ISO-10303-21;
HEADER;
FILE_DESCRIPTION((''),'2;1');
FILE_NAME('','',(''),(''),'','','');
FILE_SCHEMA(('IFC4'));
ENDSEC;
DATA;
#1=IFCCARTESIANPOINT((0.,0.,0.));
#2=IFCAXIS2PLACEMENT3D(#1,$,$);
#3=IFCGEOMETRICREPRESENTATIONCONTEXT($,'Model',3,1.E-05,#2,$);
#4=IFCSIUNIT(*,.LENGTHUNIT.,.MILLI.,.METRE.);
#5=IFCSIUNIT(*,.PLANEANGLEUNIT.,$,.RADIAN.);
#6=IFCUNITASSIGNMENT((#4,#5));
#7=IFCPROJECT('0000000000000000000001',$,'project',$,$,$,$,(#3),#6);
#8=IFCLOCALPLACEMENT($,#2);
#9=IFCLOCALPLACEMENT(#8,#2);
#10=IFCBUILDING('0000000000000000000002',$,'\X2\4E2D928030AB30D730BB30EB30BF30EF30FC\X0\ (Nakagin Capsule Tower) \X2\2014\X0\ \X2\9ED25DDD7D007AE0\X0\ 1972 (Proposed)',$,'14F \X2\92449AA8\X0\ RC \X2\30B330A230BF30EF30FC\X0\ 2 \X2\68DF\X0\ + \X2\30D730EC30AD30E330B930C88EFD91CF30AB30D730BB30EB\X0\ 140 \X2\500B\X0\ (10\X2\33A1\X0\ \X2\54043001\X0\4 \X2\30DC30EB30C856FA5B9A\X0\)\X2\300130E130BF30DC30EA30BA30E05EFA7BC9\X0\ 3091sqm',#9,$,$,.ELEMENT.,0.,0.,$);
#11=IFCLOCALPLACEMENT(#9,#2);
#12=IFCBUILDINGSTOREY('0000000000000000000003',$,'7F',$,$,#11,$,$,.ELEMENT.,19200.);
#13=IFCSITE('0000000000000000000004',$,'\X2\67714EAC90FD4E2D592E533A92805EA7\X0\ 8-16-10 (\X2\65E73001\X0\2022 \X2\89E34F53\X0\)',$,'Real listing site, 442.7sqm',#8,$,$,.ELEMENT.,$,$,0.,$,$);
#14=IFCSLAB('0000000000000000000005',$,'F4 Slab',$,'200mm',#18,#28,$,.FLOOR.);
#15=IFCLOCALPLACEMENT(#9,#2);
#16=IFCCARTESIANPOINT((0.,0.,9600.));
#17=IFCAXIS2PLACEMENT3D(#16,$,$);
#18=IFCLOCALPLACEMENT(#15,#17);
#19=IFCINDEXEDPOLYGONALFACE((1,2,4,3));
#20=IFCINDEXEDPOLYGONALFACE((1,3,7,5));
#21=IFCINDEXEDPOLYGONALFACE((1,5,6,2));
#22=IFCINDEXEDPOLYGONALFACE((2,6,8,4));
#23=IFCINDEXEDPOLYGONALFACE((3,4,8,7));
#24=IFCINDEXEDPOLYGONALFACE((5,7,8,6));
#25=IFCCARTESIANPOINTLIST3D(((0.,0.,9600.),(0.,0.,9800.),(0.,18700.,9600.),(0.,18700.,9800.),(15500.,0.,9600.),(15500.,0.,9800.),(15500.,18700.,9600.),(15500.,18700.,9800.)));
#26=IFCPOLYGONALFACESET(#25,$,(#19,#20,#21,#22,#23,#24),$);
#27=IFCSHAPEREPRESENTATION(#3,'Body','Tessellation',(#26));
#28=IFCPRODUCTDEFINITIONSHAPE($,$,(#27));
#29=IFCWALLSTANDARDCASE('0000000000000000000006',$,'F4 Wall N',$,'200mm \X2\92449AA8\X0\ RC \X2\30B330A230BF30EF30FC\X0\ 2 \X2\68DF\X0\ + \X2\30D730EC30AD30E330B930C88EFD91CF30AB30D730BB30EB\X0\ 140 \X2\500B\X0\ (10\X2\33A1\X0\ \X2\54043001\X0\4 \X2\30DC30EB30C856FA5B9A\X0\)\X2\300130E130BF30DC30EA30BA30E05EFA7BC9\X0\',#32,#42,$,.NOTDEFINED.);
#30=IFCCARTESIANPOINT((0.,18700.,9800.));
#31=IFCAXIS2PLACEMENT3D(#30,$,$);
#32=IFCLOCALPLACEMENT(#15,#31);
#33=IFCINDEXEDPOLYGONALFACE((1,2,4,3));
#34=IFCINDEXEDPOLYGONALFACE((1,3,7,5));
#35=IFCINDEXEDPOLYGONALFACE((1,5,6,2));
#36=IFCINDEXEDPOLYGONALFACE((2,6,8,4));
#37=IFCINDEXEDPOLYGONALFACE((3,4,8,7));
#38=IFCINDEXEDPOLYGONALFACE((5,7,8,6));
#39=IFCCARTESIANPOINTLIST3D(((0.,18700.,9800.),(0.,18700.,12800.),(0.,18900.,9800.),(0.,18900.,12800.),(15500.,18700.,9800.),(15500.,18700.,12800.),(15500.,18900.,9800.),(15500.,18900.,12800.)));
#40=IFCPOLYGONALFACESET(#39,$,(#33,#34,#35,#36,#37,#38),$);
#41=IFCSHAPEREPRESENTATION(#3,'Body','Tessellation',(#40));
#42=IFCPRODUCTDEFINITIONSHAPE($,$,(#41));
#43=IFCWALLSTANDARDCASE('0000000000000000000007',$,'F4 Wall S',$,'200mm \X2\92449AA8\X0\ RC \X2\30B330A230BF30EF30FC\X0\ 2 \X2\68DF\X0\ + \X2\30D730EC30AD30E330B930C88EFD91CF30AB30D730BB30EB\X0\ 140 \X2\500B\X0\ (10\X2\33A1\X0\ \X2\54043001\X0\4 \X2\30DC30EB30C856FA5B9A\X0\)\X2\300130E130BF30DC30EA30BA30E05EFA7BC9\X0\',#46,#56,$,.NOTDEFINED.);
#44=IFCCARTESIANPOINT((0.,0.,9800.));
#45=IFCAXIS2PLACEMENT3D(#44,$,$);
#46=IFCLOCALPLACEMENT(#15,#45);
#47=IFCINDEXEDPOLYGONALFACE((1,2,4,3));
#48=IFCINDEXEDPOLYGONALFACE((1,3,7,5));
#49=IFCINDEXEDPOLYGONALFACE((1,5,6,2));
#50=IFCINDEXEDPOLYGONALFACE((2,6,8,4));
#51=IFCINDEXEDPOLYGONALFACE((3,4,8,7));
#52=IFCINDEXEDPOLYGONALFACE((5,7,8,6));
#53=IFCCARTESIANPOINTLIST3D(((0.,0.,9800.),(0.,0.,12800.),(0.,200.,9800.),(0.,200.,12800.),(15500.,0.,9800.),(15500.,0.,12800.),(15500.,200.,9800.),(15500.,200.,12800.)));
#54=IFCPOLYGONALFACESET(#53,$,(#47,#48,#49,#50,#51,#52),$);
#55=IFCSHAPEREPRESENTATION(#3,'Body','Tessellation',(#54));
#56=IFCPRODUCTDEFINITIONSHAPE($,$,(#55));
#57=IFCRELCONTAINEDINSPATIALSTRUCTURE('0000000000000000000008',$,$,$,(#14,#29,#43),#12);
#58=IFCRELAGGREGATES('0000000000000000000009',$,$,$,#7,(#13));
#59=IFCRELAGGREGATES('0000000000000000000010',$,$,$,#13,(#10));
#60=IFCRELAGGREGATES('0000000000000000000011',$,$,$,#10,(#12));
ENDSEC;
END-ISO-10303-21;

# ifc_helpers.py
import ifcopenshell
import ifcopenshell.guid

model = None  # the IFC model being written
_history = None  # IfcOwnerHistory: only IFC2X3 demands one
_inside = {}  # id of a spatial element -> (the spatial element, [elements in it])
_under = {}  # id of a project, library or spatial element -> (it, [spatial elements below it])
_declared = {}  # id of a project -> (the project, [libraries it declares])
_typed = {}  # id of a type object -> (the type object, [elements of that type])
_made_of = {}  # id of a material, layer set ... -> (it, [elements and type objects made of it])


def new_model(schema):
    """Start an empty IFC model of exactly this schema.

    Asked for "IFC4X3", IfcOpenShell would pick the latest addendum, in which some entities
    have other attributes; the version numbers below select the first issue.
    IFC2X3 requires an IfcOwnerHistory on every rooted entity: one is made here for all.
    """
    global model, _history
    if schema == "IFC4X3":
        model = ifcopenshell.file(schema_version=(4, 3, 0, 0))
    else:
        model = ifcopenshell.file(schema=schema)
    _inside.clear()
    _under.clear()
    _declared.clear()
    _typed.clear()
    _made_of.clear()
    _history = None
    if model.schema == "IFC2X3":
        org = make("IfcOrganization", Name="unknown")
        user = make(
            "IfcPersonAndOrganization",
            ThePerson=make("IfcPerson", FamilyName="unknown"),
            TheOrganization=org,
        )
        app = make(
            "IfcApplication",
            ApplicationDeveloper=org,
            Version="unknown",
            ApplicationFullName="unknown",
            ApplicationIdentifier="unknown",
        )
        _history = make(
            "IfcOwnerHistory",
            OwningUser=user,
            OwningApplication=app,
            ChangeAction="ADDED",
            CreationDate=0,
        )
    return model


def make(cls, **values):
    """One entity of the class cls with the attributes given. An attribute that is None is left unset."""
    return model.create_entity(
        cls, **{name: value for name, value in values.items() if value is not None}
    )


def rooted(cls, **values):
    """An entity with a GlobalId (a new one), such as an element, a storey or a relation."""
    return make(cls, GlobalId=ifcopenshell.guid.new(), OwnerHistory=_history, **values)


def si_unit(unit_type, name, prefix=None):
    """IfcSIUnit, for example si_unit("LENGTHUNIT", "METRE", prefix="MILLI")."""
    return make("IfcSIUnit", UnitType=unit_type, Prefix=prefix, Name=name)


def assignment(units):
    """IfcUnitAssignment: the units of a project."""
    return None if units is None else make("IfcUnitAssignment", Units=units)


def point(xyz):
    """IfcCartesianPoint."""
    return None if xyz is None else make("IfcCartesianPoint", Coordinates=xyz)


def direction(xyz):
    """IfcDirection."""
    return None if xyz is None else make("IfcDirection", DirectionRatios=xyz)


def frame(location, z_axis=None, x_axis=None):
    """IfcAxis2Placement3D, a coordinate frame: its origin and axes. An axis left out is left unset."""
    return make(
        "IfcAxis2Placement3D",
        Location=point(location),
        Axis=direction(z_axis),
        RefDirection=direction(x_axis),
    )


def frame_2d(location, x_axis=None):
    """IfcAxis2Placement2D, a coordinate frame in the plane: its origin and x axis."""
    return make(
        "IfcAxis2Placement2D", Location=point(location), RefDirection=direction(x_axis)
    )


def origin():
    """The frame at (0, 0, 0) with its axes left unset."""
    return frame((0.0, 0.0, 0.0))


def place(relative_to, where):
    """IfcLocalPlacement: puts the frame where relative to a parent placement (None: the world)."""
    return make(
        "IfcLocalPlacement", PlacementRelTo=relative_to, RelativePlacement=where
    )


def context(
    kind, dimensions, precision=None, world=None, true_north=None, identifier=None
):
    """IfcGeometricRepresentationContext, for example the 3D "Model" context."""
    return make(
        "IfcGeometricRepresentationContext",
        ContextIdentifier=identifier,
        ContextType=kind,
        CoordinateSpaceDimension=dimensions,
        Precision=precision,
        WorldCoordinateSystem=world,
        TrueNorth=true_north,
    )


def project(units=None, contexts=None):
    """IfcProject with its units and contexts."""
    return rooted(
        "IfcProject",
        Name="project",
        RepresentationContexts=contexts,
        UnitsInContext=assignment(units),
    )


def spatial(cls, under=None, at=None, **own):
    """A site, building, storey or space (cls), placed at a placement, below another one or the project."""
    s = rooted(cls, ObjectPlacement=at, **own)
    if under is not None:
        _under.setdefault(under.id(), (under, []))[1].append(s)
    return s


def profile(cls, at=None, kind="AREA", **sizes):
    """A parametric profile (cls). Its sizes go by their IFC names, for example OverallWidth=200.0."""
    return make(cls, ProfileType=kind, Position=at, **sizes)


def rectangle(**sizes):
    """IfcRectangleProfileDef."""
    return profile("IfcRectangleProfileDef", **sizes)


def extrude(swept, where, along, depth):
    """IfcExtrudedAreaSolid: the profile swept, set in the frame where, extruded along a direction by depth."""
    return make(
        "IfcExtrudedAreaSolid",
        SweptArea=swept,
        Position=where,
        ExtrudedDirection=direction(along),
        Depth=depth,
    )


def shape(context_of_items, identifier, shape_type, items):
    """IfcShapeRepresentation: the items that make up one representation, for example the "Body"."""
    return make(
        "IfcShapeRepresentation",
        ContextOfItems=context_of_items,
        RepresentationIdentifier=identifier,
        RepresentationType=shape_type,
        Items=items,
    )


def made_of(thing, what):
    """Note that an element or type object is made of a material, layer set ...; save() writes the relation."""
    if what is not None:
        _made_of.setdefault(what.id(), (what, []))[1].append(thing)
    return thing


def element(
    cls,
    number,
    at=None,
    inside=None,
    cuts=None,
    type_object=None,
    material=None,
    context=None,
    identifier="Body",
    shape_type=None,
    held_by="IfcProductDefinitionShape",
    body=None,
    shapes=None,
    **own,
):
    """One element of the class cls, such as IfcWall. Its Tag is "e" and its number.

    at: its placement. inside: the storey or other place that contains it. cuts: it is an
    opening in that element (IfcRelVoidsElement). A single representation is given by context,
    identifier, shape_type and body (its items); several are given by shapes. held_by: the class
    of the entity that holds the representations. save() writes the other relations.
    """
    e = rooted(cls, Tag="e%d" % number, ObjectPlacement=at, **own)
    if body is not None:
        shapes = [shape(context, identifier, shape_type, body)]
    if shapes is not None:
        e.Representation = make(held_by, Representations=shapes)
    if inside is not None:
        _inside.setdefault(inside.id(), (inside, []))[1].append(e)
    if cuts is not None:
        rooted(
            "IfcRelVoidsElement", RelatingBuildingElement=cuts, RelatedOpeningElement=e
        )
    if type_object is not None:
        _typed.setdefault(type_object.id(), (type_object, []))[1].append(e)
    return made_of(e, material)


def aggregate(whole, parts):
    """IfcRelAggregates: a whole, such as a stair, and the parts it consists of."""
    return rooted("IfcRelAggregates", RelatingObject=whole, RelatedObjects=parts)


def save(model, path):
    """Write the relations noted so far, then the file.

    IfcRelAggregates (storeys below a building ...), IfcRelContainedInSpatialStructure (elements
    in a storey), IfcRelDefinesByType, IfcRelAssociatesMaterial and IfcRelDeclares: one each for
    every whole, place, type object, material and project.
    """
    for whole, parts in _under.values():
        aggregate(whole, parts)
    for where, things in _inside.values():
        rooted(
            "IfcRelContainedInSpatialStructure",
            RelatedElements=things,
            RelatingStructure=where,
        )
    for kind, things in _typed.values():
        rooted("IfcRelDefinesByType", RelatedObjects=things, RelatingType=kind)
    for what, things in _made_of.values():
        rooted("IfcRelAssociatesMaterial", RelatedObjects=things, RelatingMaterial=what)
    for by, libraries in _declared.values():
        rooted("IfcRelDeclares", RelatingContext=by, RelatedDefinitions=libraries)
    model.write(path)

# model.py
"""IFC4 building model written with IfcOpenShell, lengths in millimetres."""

from ifc_helpers import new_model, si_unit, frame, frame_2d, origin, place, context, project, spatial, rectangle, extrude, element, save


model = new_model("IFC4")

# Units and contexts
model_context = context("Model", 3, precision=1e-05, world=origin())
ifc_project = project(units=[si_unit("LENGTHUNIT", "METRE", prefix="MILLI"), si_unit("PLANEANGLEUNIT", "RADIAN")], contexts=[model_context])

# Site, building, storey
site_placement = place(None, origin())
site = spatial("IfcSite", under=ifc_project, at=site_placement, Name="東京都中央区銀座 8-16-10 (旧、2022 解体)", ObjectType="Real listing site, 442.7sqm", CompositionType="ELEMENT", RefElevation=0.0)
building_placement = place(site_placement, origin())
building = spatial("IfcBuilding", under=site, at=building_placement, Name="中銀カプセルタワー (Nakagin Capsule Tower) — 黒川紀章 1972 (Proposed)", ObjectType="14F 鉄骨 RC コアタワー 2 棟 + プレキャスト軽量カプセル 140 個 (10㎡ 各、4 ボルト固定)、メタボリズム建築 3091sqm", CompositionType="ELEMENT", ElevationOfRefHeight=0.0, ElevationOfTerrain=0.0)
storey_placement = place(building_placement, origin())
storey = spatial("IfcBuildingStorey", under=building, at=storey_placement, Name="7F", CompositionType="ELEMENT", Elevation=19200.0)

# Slab
placement = place(building_placement, origin())
slab_placement = place(placement, frame((0.0, 0.0, 9600.0)))
element("IfcSlab", 1, at=slab_placement, inside=storey, Name="F4 Slab", ObjectType="200mm", PredefinedType="FLOOR", context=model_context, shape_type="SweptSolid", body=[
    extrude(rectangle(XDim=15500.0, YDim=18700.0, at=frame_2d((7750.0, 9350.0))), frame((0.0, 0.0, 9600.0)), (0.0, 0.0, 1.0), 200.0),
])

# Walls
wall_1_placement = place(placement, frame((0.0, 18700.0, 9800.0)))
element("IfcWallStandardCase", 2, at=wall_1_placement, inside=storey, Name="F4 Wall N", ObjectType="200mm 鉄骨 RC コアタワー 2 棟 + プレキャスト軽量カプセル 140 個 (10㎡ 各、4 ボルト固定)、メタボリズム建築", PredefinedType="NOTDEFINED", context=model_context, shape_type="SweptSolid", body=[
    extrude(rectangle(XDim=15500.0, YDim=200.0, at=frame_2d((7750.0, 100.0))), frame((0.0, 18700.0, 9800.0)), (0.0, 0.0, 1.0), 3000.0),
])
wall_2_placement = place(placement, frame((0.0, 0.0, 9800.0)))
element("IfcWallStandardCase", 3, at=wall_2_placement, inside=storey, Name="F4 Wall S", ObjectType="200mm 鉄骨 RC コアタワー 2 棟 + プレキャスト軽量カプセル 140 個 (10㎡ 各、4 ボルト固定)、メタボリズム建築", PredefinedType="NOTDEFINED", context=model_context, shape_type="SweptSolid", body=[
    extrude(rectangle(XDim=15500.0, YDim=200.0, at=frame_2d((7750.0, 100.0))), frame((0.0, 0.0, 9800.0)), (0.0, 0.0, 1.0), 3000.0),
])

save(model, "model.ifc")
